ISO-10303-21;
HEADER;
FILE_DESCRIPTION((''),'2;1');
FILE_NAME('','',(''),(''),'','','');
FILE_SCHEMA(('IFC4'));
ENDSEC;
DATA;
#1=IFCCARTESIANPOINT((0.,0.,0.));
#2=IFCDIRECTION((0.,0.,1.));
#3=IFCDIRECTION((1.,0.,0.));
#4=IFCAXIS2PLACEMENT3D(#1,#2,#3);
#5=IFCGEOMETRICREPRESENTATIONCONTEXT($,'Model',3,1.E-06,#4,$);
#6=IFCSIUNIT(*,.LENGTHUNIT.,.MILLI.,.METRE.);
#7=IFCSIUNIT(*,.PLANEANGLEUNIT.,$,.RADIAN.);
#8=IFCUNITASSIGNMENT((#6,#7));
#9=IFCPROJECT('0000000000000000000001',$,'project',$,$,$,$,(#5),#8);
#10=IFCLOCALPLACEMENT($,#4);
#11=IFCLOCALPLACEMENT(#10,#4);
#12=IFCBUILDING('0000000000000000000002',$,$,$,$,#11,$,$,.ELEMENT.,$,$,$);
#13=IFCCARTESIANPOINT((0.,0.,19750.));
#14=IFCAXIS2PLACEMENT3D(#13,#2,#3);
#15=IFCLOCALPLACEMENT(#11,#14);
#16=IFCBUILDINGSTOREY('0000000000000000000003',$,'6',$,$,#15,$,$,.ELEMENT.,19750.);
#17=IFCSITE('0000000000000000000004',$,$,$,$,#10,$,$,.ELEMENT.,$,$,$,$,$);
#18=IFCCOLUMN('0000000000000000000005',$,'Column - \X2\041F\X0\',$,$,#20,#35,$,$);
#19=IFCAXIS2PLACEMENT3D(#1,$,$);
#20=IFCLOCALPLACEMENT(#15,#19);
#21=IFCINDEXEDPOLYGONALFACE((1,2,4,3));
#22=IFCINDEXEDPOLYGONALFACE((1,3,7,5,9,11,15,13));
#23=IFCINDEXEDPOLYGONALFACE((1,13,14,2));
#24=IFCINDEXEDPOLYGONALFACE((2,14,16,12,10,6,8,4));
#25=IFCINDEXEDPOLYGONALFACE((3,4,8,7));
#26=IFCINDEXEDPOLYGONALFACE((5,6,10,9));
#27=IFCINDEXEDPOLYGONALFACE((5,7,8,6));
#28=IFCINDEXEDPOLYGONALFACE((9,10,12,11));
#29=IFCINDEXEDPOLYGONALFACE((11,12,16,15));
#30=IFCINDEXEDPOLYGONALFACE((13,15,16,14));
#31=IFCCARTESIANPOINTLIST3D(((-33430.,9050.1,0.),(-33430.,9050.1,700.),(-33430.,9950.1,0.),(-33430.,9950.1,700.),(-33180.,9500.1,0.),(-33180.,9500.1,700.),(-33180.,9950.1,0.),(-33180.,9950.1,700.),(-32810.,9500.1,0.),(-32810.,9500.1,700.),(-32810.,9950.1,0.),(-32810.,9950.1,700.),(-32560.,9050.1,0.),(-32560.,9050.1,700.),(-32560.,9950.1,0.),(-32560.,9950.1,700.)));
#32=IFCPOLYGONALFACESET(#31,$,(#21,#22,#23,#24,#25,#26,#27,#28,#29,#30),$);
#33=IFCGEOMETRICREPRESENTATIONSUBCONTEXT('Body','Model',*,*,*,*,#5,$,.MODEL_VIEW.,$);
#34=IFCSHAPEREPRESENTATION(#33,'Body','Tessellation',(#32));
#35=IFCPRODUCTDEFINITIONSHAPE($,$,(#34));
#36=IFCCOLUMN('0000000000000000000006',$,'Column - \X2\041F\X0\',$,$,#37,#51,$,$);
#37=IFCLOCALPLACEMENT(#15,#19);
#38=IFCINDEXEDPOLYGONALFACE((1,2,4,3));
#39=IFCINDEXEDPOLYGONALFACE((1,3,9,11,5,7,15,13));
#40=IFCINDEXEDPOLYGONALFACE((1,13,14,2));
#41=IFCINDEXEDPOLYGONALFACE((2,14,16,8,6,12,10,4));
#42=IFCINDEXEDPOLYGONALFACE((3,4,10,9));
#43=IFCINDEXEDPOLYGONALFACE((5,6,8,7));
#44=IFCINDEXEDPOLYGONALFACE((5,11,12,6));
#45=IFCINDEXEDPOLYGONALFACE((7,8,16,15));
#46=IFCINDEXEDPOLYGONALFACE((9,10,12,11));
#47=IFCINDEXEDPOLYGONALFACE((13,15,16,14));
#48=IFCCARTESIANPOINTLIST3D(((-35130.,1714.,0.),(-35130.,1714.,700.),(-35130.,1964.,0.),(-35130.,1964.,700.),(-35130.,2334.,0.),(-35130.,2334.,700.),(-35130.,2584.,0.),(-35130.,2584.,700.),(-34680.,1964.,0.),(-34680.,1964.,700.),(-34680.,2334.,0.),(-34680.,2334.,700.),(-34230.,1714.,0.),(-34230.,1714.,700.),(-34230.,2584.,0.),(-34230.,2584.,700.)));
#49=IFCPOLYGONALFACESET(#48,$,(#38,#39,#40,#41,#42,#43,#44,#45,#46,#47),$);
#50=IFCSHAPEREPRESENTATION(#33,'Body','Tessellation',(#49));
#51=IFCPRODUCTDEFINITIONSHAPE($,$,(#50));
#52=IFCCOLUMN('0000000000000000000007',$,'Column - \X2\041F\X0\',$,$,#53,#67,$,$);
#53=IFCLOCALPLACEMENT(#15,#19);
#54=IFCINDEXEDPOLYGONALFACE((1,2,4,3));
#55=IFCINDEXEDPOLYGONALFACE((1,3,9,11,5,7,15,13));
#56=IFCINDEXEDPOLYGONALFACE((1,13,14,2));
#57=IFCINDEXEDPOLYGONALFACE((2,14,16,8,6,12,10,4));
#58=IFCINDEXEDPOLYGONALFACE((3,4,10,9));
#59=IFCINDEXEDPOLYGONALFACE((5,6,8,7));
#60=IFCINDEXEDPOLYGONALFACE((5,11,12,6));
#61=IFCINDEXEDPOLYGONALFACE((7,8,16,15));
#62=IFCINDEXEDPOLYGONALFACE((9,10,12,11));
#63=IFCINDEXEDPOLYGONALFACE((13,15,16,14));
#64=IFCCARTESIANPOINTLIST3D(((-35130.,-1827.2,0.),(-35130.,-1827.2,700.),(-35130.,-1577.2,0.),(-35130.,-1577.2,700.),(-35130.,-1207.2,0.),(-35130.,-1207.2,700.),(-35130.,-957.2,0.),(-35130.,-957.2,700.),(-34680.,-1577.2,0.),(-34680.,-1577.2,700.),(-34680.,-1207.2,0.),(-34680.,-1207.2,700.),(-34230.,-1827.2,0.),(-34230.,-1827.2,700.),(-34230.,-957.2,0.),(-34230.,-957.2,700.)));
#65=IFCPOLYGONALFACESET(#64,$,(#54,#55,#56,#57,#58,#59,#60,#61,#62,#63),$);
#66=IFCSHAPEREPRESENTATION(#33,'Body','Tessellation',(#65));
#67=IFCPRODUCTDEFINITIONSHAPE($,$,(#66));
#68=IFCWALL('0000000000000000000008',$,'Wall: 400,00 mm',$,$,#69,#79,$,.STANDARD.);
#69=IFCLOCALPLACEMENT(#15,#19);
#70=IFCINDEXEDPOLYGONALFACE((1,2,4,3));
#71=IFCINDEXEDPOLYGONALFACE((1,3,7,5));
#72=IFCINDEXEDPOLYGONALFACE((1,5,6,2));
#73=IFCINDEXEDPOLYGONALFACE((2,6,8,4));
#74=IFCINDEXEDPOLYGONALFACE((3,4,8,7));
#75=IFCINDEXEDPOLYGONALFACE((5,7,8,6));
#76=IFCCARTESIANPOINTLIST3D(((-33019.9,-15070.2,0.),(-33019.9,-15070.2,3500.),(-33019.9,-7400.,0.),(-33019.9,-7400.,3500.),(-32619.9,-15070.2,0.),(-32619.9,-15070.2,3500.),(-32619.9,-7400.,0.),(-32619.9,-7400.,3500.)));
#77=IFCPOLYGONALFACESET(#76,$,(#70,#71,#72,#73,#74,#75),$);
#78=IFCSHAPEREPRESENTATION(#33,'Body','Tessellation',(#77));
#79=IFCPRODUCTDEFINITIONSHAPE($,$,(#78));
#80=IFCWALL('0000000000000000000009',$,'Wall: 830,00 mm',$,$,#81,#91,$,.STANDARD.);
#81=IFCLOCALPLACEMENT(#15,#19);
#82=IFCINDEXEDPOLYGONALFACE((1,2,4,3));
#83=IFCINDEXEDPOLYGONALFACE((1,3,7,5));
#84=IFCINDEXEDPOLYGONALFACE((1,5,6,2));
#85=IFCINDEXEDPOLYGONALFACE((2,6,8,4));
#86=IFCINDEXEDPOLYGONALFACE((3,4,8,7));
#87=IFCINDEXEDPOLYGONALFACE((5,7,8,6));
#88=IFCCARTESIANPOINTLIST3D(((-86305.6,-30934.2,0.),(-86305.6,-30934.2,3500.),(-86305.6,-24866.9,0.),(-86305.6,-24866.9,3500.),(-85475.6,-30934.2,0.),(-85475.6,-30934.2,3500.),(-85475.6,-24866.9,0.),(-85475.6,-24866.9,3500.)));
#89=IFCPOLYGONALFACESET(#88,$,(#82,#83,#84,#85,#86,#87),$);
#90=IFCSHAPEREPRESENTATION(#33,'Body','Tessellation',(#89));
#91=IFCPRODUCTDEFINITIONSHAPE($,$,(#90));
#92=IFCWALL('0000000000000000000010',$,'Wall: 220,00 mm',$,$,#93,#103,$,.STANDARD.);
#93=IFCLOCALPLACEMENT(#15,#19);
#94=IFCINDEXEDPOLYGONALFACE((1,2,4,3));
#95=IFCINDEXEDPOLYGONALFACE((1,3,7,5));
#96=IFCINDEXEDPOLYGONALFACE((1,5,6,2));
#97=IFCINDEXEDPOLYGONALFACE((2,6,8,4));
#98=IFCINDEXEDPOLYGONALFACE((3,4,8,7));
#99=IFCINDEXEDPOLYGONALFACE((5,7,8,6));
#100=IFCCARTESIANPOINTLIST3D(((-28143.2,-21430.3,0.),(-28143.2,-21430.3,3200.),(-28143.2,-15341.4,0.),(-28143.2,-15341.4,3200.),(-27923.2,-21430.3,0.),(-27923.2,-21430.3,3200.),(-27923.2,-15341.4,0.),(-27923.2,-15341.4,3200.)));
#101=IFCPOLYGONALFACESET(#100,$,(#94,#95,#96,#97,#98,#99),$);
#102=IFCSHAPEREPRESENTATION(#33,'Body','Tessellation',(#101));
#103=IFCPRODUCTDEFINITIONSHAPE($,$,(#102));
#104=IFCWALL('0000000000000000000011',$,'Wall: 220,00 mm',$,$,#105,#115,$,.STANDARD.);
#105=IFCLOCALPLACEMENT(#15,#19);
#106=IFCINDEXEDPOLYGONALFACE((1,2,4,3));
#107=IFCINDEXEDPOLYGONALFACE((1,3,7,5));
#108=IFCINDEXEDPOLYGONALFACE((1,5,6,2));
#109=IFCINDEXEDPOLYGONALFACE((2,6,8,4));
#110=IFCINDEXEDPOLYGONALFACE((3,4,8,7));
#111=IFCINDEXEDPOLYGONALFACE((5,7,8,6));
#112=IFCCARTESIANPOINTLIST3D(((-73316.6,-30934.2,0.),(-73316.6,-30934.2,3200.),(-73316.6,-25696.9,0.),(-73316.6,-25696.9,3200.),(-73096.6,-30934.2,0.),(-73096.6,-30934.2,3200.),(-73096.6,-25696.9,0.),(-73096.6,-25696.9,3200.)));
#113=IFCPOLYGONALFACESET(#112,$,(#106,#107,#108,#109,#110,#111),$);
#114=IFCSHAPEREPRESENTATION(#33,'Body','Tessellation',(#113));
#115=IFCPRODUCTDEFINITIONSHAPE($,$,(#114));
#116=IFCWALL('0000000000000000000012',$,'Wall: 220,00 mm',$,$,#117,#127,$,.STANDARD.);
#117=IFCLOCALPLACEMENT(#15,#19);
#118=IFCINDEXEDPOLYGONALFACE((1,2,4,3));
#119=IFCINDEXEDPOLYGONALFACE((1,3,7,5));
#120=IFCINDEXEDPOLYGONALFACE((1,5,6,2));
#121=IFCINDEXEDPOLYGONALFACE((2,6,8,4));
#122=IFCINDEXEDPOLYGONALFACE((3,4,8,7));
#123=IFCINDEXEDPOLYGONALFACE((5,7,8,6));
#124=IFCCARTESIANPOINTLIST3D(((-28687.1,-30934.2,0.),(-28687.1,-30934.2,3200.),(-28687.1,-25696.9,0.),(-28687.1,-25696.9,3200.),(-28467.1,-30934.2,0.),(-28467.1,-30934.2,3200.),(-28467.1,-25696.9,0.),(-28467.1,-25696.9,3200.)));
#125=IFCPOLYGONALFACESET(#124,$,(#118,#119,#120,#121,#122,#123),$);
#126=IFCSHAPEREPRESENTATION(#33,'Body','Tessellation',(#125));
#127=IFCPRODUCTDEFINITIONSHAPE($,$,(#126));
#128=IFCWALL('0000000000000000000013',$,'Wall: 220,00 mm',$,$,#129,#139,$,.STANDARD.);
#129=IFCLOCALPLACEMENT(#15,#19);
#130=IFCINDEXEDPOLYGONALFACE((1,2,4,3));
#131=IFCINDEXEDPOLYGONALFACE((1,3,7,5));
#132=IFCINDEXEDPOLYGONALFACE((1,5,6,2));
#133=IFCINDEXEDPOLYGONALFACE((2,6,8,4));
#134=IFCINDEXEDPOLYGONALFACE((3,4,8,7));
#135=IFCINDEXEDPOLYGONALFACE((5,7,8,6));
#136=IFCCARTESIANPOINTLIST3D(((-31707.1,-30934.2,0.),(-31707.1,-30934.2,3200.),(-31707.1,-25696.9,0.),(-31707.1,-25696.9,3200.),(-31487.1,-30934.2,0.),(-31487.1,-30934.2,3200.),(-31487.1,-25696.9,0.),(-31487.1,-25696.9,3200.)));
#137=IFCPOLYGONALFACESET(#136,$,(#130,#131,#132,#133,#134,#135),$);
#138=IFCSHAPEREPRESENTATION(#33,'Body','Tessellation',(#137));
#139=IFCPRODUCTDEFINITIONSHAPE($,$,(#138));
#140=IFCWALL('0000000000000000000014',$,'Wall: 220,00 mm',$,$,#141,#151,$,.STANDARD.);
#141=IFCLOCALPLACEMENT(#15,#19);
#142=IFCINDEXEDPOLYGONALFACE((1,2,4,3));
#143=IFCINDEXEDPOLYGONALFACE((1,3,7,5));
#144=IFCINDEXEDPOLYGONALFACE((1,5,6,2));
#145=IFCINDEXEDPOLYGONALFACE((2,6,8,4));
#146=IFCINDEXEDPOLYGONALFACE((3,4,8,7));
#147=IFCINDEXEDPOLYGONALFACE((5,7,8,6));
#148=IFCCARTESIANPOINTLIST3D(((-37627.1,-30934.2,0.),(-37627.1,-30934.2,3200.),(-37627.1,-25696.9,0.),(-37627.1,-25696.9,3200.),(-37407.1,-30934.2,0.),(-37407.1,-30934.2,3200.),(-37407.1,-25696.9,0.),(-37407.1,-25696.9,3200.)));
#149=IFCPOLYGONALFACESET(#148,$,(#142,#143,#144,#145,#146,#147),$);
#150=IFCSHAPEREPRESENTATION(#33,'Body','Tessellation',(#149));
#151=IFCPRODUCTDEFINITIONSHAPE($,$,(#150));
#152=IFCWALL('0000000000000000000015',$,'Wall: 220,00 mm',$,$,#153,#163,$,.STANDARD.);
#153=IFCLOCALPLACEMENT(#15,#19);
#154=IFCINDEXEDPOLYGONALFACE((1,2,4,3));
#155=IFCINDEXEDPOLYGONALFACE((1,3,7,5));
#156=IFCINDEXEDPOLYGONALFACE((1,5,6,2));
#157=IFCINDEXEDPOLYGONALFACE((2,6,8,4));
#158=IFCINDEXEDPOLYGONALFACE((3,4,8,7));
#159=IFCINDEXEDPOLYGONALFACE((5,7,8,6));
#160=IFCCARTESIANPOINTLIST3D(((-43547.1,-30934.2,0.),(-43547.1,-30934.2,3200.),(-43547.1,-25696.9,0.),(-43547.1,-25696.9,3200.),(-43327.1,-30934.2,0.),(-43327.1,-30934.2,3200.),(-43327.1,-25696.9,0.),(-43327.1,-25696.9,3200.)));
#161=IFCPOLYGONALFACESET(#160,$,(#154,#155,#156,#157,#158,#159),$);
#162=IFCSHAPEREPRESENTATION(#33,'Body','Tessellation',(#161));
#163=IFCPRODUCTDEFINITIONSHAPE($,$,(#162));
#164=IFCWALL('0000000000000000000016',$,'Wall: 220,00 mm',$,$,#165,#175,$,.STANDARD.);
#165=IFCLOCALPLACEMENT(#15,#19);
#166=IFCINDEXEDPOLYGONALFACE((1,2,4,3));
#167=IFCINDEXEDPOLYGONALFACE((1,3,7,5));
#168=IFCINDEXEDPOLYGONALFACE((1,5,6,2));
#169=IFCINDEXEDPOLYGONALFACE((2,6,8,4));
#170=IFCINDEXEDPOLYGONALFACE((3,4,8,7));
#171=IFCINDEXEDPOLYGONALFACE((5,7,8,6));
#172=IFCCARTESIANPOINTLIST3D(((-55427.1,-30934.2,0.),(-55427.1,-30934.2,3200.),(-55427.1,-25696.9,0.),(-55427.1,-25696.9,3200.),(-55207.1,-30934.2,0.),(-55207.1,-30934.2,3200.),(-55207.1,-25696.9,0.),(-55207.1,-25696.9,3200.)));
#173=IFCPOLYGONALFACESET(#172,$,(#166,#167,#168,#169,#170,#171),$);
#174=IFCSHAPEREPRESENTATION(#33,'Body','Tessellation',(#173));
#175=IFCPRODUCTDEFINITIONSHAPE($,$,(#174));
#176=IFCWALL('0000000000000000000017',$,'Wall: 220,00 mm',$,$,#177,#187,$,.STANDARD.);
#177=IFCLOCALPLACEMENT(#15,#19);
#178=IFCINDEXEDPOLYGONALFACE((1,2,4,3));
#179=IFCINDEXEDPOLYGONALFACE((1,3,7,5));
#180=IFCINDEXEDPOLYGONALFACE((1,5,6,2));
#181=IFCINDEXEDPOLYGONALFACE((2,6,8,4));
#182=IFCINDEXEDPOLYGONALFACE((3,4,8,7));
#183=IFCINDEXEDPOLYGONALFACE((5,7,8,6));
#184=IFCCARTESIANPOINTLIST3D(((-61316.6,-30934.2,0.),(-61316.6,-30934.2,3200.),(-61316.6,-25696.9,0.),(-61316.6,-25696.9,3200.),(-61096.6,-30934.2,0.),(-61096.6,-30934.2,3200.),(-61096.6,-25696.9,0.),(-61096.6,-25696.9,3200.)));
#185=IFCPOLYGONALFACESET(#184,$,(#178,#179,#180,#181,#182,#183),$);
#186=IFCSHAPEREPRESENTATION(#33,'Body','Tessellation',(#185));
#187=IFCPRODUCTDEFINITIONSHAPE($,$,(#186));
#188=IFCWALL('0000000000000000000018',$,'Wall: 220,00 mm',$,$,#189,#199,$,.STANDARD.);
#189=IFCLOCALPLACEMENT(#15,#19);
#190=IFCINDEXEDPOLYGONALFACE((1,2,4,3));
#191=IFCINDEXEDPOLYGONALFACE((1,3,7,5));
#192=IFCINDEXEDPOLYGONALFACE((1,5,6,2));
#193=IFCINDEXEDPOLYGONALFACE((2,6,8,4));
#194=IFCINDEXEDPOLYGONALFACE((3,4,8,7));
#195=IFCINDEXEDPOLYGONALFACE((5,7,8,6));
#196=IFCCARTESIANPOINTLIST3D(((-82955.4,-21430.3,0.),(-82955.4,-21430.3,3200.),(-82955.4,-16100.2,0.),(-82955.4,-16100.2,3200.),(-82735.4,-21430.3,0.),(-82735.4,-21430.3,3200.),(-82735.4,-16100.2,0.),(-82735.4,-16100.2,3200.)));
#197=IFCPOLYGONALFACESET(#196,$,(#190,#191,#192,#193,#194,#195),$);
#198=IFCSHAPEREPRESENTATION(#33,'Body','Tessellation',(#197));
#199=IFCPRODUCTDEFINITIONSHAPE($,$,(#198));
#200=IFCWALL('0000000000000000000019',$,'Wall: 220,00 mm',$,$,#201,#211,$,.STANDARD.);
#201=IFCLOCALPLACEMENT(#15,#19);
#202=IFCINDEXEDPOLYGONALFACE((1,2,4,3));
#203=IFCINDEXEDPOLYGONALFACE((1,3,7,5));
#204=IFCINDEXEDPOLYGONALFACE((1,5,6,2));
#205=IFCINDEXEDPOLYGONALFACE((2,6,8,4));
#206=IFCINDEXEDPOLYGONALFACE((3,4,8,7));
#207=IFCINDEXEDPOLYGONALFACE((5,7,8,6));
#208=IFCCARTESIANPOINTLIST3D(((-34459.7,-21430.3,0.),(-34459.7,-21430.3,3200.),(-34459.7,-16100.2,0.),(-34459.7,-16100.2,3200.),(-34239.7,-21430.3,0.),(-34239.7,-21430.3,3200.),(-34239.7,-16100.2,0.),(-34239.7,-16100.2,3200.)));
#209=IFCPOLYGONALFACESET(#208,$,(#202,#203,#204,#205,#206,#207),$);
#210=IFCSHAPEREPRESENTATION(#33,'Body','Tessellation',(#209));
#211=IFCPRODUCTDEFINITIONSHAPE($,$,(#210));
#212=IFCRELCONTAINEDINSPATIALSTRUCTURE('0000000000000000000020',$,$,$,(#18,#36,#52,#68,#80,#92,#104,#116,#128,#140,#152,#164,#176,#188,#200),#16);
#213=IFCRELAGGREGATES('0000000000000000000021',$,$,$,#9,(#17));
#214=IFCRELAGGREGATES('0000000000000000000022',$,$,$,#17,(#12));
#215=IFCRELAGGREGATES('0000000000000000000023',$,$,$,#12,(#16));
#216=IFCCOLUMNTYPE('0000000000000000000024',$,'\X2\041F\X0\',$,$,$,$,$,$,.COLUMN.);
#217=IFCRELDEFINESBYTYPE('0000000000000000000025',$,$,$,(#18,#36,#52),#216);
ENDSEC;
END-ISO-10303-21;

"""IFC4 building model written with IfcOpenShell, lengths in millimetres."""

from ifc_helpers import new_model, si_unit, frame, origin_with_axes, place, context, subcontext, project, spatial, line, indexed_curve, outline, extrude, source, transform, mapped, type_object, element, save


model = new_model("IFC4")

# Units and contexts
model_context = context("Model", 3, precision=1e-06, world=origin_with_axes())
body_context = subcontext(model_context, "Body", "Model", "MODEL_VIEW")
ifc_project = project(units=[si_unit("LENGTHUNIT", "METRE", prefix="MILLI"), si_unit("PLANEANGLEUNIT", "RADIAN")], contexts=[model_context])

# Site, building, storey
site_placement = place(None, origin_with_axes())
site = spatial("IfcSite", under=ifc_project, at=site_placement, CompositionType="ELEMENT")
building_placement = place(site_placement, origin_with_axes())
building = spatial("IfcBuilding", under=site, at=building_placement, CompositionType="ELEMENT")
storey_placement = place(building_placement, frame((0.0, 0.0, 19750.0), z_axis=(0.0, 0.0, 1.0), x_axis=(1.0, 0.0, 0.0)))
storey = spatial("IfcBuildingStorey", under=building, at=storey_placement, Name="6", CompositionType="ELEMENT", Elevation=19750.0)

# Columns
column_type = type_object("IfcColumnType", Name="П", PredefinedType="COLUMN")
shared_shape = source(origin_with_axes(), body_context, "Body", "SweptSolid", [
    extrude(outline(indexed_curve([(-450.0, -435.0), (450.0, -435.0), (450.0, -185.0), (0.0, -185.0), (0.0, 185.0), (450.0, 185.0), (450.0, 435.0), (-450.0, 435.0)], segments=[line(1, 2), line(2, 3), line(3, 4), line(4, 5), line(5, 6), line(6, 7), line(7, 8), line(8, 1)])), origin_with_axes(), (0.0, 0.0, 1.0), 700.0),
])
for number, where, z_axis, x_axis, name in (
    (1, (-32995.0, 9500.1, 0.0), (0.0, 0.0, 1.0), (0.0, 1.0, 0.0), "Column - П"),
    (2, (-34680.0, 2149.0, 0.0), (0.0, 0.0, 1.0), (-1.0, 0.0, 0.0), "Column - П"),
    (3, (-34680.0, -1392.2, 0.0), (0.0, 0.0, 1.0), (-1.0, 0.0, 0.0), "Column - П"),
):
    element("IfcColumn", number, at=place(storey_placement, frame(where, z_axis=z_axis, x_axis=x_axis)), inside=storey, type_object=column_type, Name=name, context=body_context, shape_type="MappedRepresentation", body=[
        mapped(shared_shape, transform((0.0, 0.0, 0.0), x_axis=(1.0, 0.0, 0.0), y_axis=(0.0, 1.0, 0.0), z_axis=(0.0, 0.0, 1.0), scale=1.0)),
    ])

# Walls
wall_1_placement = place(storey_placement, frame((-33019.9, -7400.0, 0.0), z_axis=(0.0, 0.0, 1.0), x_axis=(0.0, -1.0, 0.0)))
element("IfcWall", 4, at=wall_1_placement, inside=storey, Name="Wall: 400,00 mm", PredefinedType="STANDARD", context=body_context, shape_type="SweptSolid", body=[
    extrude(outline(indexed_curve([(0.0, 0.0), (7670.2, 0.0), (7670.2, 400.0), (0.0, 400.0)], segments=[line(1, 2), line(2, 3), line(3, 4), line(4, 1)])), origin_with_axes(), (0.0, 0.0, 1.0), 3500.0),
])
wall_2_placement = place(storey_placement, frame((-86305.6, -24866.9, 0.0), z_axis=(0.0, 0.0, 1.0), x_axis=(0.0, -1.0, 0.0)))
element("IfcWall", 5, at=wall_2_placement, inside=storey, Name="Wall: 830,00 mm", PredefinedType="STANDARD", context=body_context, shape_type="SweptSolid", body=[
    extrude(outline(indexed_curve([(0.0, 0.0), (6067.4, 0.0), (6067.4, 830.0), (0.0, 830.0)], segments=[line(1, 2), line(2, 3), line(3, 4), line(4, 1)])), origin_with_axes(), (0.0, 0.0, 1.0), 3500.0),
])
wall_3_placement = place(storey_placement, frame((-28033.2, -15341.4, 0.0), z_axis=(0.0, 0.0, 1.0), x_axis=(0.0, -1.0, 0.0)))
element("IfcWall", 6, at=wall_3_placement, inside=storey, Name="Wall: 220,00 mm", PredefinedType="STANDARD", context=body_context, shape_type="SweptSolid", body=[
    extrude(outline(indexed_curve([(0.0, -110.0), (6088.9, -110.0), (6088.9, 110.0), (0.0, 110.0)], segments=[line(1, 2), line(2, 3), line(3, 4), line(4, 1)])), origin_with_axes(), (0.0, 0.0, 1.0), 3200.0),
])
wall_4_placement = place(storey_placement, frame((-73316.6, -30934.2, 0.0), z_axis=(0.0, 0.0, 1.0), x_axis=(0.0, 1.0, 0.0)))
element("IfcWall", 7, at=wall_4_placement, inside=storey, Name="Wall: 220,00 mm", PredefinedType="STANDARD", context=body_context, shape_type="SweptSolid", body=[
    extrude(outline(indexed_curve([(0.0, -220.0), (5237.4, -220.0), (5237.4, 0.0), (0.0, 0.0)], segments=[line(1, 2), line(2, 3), line(3, 4), line(4, 1)])), origin_with_axes(), (0.0, 0.0, 1.0), 3200.0),
])
wall_5_placement = place(storey_placement, frame((-28467.1, -25696.9, 0.0), z_axis=(0.0, 0.0, 1.0), x_axis=(0.0, -1.0, 0.0)))
element("IfcWall", 8, at=wall_5_placement, inside=storey, Name="Wall: 220,00 mm", PredefinedType="STANDARD", context=body_context, shape_type="SweptSolid", body=[
    extrude(outline(indexed_curve([(0.0, -220.0), (5237.4, -220.0), (5237.4, 0.0), (0.0, 0.0)], segments=[line(1, 2), line(2, 3), line(3, 4), line(4, 1)])), origin_with_axes(), (0.0, 0.0, 1.0), 3200.0),
])
for number, where, z_axis, x_axis, name in (
    (9, (-31487.1, -30934.2, 0.0), (0.0, 0.0, 1.0), (0.0, 1.0, 0.0), "Wall: 220,00 mm"),
    (10, (-37407.1, -30934.2, 0.0), (0.0, 0.0, 1.0), (0.0, 1.0, 0.0), "Wall: 220,00 mm"),
    (11, (-43327.1, -30934.2, 0.0), (0.0, 0.0, 1.0), (0.0, 1.0, 0.0), "Wall: 220,00 mm"),
    (12, (-55207.1, -30934.2, 0.0), (0.0, 0.0, 1.0), (0.0, 1.0, 0.0), "Wall: 220,00 mm"),
):
    element("IfcWall", number, at=place(storey_placement, frame(where, z_axis=z_axis, x_axis=x_axis)), inside=storey, Name=name, PredefinedType="STANDARD", context=body_context, shape_type="SweptSolid", body=[
        extrude(outline(indexed_curve([(0.0, 0.0), (5237.4, 0.0), (5237.4, 220.0), (0.0, 220.0)], segments=[line(1, 2), line(2, 3), line(3, 4), line(4, 1)])), origin_with_axes(), (0.0, 0.0, 1.0), 3200.0),
    ])
wall_6_placement = place(storey_placement, frame((-61096.6, -30934.2, 0.0), z_axis=(0.0, 0.0, 1.0), x_axis=(0.0, 1.0, 0.0)))
element("IfcWall", 13, at=wall_6_placement, inside=storey, Name="Wall: 220,00 mm", PredefinedType="STANDARD", context=body_context, shape_type="SweptSolid", body=[
    extrude(outline(indexed_curve([(0.0, 0.0), (5237.4, 0.0), (5237.4, 220.0), (0.0, 220.0)], segments=[line(1, 2), line(2, 3), line(3, 4), line(4, 1)])), origin_with_axes(), (0.0, 0.0, 1.0), 3200.0),
])
for number, where, z_axis, x_axis, name in (
    (14, (-82735.4, -16100.2, 0.0), (0.0, 0.0, 1.0), (0.0, -1.0, 0.0), "Wall: 220,00 mm"),
    (15, (-34239.7, -16100.2, 0.0), (0.0, 0.0, 1.0), (0.0, -1.0, 0.0), "Wall: 220,00 mm"),
):
    element("IfcWall", number, at=place(storey_placement, frame(where, z_axis=z_axis, x_axis=x_axis)), inside=storey, Name=name, PredefinedType="STANDARD", context=body_context, shape_type="SweptSolid", body=[
        extrude(outline(indexed_curve([(0.0, -220.0), (5330.0, -220.0), (5330.0, 0.0), (0.0, 0.0)], segments=[line(1, 2), line(2, 3), line(3, 4), line(4, 1)])), origin_with_axes(), (0.0, 0.0, 1.0), 3200.0),
    ])

save(model, "model.ifc")
